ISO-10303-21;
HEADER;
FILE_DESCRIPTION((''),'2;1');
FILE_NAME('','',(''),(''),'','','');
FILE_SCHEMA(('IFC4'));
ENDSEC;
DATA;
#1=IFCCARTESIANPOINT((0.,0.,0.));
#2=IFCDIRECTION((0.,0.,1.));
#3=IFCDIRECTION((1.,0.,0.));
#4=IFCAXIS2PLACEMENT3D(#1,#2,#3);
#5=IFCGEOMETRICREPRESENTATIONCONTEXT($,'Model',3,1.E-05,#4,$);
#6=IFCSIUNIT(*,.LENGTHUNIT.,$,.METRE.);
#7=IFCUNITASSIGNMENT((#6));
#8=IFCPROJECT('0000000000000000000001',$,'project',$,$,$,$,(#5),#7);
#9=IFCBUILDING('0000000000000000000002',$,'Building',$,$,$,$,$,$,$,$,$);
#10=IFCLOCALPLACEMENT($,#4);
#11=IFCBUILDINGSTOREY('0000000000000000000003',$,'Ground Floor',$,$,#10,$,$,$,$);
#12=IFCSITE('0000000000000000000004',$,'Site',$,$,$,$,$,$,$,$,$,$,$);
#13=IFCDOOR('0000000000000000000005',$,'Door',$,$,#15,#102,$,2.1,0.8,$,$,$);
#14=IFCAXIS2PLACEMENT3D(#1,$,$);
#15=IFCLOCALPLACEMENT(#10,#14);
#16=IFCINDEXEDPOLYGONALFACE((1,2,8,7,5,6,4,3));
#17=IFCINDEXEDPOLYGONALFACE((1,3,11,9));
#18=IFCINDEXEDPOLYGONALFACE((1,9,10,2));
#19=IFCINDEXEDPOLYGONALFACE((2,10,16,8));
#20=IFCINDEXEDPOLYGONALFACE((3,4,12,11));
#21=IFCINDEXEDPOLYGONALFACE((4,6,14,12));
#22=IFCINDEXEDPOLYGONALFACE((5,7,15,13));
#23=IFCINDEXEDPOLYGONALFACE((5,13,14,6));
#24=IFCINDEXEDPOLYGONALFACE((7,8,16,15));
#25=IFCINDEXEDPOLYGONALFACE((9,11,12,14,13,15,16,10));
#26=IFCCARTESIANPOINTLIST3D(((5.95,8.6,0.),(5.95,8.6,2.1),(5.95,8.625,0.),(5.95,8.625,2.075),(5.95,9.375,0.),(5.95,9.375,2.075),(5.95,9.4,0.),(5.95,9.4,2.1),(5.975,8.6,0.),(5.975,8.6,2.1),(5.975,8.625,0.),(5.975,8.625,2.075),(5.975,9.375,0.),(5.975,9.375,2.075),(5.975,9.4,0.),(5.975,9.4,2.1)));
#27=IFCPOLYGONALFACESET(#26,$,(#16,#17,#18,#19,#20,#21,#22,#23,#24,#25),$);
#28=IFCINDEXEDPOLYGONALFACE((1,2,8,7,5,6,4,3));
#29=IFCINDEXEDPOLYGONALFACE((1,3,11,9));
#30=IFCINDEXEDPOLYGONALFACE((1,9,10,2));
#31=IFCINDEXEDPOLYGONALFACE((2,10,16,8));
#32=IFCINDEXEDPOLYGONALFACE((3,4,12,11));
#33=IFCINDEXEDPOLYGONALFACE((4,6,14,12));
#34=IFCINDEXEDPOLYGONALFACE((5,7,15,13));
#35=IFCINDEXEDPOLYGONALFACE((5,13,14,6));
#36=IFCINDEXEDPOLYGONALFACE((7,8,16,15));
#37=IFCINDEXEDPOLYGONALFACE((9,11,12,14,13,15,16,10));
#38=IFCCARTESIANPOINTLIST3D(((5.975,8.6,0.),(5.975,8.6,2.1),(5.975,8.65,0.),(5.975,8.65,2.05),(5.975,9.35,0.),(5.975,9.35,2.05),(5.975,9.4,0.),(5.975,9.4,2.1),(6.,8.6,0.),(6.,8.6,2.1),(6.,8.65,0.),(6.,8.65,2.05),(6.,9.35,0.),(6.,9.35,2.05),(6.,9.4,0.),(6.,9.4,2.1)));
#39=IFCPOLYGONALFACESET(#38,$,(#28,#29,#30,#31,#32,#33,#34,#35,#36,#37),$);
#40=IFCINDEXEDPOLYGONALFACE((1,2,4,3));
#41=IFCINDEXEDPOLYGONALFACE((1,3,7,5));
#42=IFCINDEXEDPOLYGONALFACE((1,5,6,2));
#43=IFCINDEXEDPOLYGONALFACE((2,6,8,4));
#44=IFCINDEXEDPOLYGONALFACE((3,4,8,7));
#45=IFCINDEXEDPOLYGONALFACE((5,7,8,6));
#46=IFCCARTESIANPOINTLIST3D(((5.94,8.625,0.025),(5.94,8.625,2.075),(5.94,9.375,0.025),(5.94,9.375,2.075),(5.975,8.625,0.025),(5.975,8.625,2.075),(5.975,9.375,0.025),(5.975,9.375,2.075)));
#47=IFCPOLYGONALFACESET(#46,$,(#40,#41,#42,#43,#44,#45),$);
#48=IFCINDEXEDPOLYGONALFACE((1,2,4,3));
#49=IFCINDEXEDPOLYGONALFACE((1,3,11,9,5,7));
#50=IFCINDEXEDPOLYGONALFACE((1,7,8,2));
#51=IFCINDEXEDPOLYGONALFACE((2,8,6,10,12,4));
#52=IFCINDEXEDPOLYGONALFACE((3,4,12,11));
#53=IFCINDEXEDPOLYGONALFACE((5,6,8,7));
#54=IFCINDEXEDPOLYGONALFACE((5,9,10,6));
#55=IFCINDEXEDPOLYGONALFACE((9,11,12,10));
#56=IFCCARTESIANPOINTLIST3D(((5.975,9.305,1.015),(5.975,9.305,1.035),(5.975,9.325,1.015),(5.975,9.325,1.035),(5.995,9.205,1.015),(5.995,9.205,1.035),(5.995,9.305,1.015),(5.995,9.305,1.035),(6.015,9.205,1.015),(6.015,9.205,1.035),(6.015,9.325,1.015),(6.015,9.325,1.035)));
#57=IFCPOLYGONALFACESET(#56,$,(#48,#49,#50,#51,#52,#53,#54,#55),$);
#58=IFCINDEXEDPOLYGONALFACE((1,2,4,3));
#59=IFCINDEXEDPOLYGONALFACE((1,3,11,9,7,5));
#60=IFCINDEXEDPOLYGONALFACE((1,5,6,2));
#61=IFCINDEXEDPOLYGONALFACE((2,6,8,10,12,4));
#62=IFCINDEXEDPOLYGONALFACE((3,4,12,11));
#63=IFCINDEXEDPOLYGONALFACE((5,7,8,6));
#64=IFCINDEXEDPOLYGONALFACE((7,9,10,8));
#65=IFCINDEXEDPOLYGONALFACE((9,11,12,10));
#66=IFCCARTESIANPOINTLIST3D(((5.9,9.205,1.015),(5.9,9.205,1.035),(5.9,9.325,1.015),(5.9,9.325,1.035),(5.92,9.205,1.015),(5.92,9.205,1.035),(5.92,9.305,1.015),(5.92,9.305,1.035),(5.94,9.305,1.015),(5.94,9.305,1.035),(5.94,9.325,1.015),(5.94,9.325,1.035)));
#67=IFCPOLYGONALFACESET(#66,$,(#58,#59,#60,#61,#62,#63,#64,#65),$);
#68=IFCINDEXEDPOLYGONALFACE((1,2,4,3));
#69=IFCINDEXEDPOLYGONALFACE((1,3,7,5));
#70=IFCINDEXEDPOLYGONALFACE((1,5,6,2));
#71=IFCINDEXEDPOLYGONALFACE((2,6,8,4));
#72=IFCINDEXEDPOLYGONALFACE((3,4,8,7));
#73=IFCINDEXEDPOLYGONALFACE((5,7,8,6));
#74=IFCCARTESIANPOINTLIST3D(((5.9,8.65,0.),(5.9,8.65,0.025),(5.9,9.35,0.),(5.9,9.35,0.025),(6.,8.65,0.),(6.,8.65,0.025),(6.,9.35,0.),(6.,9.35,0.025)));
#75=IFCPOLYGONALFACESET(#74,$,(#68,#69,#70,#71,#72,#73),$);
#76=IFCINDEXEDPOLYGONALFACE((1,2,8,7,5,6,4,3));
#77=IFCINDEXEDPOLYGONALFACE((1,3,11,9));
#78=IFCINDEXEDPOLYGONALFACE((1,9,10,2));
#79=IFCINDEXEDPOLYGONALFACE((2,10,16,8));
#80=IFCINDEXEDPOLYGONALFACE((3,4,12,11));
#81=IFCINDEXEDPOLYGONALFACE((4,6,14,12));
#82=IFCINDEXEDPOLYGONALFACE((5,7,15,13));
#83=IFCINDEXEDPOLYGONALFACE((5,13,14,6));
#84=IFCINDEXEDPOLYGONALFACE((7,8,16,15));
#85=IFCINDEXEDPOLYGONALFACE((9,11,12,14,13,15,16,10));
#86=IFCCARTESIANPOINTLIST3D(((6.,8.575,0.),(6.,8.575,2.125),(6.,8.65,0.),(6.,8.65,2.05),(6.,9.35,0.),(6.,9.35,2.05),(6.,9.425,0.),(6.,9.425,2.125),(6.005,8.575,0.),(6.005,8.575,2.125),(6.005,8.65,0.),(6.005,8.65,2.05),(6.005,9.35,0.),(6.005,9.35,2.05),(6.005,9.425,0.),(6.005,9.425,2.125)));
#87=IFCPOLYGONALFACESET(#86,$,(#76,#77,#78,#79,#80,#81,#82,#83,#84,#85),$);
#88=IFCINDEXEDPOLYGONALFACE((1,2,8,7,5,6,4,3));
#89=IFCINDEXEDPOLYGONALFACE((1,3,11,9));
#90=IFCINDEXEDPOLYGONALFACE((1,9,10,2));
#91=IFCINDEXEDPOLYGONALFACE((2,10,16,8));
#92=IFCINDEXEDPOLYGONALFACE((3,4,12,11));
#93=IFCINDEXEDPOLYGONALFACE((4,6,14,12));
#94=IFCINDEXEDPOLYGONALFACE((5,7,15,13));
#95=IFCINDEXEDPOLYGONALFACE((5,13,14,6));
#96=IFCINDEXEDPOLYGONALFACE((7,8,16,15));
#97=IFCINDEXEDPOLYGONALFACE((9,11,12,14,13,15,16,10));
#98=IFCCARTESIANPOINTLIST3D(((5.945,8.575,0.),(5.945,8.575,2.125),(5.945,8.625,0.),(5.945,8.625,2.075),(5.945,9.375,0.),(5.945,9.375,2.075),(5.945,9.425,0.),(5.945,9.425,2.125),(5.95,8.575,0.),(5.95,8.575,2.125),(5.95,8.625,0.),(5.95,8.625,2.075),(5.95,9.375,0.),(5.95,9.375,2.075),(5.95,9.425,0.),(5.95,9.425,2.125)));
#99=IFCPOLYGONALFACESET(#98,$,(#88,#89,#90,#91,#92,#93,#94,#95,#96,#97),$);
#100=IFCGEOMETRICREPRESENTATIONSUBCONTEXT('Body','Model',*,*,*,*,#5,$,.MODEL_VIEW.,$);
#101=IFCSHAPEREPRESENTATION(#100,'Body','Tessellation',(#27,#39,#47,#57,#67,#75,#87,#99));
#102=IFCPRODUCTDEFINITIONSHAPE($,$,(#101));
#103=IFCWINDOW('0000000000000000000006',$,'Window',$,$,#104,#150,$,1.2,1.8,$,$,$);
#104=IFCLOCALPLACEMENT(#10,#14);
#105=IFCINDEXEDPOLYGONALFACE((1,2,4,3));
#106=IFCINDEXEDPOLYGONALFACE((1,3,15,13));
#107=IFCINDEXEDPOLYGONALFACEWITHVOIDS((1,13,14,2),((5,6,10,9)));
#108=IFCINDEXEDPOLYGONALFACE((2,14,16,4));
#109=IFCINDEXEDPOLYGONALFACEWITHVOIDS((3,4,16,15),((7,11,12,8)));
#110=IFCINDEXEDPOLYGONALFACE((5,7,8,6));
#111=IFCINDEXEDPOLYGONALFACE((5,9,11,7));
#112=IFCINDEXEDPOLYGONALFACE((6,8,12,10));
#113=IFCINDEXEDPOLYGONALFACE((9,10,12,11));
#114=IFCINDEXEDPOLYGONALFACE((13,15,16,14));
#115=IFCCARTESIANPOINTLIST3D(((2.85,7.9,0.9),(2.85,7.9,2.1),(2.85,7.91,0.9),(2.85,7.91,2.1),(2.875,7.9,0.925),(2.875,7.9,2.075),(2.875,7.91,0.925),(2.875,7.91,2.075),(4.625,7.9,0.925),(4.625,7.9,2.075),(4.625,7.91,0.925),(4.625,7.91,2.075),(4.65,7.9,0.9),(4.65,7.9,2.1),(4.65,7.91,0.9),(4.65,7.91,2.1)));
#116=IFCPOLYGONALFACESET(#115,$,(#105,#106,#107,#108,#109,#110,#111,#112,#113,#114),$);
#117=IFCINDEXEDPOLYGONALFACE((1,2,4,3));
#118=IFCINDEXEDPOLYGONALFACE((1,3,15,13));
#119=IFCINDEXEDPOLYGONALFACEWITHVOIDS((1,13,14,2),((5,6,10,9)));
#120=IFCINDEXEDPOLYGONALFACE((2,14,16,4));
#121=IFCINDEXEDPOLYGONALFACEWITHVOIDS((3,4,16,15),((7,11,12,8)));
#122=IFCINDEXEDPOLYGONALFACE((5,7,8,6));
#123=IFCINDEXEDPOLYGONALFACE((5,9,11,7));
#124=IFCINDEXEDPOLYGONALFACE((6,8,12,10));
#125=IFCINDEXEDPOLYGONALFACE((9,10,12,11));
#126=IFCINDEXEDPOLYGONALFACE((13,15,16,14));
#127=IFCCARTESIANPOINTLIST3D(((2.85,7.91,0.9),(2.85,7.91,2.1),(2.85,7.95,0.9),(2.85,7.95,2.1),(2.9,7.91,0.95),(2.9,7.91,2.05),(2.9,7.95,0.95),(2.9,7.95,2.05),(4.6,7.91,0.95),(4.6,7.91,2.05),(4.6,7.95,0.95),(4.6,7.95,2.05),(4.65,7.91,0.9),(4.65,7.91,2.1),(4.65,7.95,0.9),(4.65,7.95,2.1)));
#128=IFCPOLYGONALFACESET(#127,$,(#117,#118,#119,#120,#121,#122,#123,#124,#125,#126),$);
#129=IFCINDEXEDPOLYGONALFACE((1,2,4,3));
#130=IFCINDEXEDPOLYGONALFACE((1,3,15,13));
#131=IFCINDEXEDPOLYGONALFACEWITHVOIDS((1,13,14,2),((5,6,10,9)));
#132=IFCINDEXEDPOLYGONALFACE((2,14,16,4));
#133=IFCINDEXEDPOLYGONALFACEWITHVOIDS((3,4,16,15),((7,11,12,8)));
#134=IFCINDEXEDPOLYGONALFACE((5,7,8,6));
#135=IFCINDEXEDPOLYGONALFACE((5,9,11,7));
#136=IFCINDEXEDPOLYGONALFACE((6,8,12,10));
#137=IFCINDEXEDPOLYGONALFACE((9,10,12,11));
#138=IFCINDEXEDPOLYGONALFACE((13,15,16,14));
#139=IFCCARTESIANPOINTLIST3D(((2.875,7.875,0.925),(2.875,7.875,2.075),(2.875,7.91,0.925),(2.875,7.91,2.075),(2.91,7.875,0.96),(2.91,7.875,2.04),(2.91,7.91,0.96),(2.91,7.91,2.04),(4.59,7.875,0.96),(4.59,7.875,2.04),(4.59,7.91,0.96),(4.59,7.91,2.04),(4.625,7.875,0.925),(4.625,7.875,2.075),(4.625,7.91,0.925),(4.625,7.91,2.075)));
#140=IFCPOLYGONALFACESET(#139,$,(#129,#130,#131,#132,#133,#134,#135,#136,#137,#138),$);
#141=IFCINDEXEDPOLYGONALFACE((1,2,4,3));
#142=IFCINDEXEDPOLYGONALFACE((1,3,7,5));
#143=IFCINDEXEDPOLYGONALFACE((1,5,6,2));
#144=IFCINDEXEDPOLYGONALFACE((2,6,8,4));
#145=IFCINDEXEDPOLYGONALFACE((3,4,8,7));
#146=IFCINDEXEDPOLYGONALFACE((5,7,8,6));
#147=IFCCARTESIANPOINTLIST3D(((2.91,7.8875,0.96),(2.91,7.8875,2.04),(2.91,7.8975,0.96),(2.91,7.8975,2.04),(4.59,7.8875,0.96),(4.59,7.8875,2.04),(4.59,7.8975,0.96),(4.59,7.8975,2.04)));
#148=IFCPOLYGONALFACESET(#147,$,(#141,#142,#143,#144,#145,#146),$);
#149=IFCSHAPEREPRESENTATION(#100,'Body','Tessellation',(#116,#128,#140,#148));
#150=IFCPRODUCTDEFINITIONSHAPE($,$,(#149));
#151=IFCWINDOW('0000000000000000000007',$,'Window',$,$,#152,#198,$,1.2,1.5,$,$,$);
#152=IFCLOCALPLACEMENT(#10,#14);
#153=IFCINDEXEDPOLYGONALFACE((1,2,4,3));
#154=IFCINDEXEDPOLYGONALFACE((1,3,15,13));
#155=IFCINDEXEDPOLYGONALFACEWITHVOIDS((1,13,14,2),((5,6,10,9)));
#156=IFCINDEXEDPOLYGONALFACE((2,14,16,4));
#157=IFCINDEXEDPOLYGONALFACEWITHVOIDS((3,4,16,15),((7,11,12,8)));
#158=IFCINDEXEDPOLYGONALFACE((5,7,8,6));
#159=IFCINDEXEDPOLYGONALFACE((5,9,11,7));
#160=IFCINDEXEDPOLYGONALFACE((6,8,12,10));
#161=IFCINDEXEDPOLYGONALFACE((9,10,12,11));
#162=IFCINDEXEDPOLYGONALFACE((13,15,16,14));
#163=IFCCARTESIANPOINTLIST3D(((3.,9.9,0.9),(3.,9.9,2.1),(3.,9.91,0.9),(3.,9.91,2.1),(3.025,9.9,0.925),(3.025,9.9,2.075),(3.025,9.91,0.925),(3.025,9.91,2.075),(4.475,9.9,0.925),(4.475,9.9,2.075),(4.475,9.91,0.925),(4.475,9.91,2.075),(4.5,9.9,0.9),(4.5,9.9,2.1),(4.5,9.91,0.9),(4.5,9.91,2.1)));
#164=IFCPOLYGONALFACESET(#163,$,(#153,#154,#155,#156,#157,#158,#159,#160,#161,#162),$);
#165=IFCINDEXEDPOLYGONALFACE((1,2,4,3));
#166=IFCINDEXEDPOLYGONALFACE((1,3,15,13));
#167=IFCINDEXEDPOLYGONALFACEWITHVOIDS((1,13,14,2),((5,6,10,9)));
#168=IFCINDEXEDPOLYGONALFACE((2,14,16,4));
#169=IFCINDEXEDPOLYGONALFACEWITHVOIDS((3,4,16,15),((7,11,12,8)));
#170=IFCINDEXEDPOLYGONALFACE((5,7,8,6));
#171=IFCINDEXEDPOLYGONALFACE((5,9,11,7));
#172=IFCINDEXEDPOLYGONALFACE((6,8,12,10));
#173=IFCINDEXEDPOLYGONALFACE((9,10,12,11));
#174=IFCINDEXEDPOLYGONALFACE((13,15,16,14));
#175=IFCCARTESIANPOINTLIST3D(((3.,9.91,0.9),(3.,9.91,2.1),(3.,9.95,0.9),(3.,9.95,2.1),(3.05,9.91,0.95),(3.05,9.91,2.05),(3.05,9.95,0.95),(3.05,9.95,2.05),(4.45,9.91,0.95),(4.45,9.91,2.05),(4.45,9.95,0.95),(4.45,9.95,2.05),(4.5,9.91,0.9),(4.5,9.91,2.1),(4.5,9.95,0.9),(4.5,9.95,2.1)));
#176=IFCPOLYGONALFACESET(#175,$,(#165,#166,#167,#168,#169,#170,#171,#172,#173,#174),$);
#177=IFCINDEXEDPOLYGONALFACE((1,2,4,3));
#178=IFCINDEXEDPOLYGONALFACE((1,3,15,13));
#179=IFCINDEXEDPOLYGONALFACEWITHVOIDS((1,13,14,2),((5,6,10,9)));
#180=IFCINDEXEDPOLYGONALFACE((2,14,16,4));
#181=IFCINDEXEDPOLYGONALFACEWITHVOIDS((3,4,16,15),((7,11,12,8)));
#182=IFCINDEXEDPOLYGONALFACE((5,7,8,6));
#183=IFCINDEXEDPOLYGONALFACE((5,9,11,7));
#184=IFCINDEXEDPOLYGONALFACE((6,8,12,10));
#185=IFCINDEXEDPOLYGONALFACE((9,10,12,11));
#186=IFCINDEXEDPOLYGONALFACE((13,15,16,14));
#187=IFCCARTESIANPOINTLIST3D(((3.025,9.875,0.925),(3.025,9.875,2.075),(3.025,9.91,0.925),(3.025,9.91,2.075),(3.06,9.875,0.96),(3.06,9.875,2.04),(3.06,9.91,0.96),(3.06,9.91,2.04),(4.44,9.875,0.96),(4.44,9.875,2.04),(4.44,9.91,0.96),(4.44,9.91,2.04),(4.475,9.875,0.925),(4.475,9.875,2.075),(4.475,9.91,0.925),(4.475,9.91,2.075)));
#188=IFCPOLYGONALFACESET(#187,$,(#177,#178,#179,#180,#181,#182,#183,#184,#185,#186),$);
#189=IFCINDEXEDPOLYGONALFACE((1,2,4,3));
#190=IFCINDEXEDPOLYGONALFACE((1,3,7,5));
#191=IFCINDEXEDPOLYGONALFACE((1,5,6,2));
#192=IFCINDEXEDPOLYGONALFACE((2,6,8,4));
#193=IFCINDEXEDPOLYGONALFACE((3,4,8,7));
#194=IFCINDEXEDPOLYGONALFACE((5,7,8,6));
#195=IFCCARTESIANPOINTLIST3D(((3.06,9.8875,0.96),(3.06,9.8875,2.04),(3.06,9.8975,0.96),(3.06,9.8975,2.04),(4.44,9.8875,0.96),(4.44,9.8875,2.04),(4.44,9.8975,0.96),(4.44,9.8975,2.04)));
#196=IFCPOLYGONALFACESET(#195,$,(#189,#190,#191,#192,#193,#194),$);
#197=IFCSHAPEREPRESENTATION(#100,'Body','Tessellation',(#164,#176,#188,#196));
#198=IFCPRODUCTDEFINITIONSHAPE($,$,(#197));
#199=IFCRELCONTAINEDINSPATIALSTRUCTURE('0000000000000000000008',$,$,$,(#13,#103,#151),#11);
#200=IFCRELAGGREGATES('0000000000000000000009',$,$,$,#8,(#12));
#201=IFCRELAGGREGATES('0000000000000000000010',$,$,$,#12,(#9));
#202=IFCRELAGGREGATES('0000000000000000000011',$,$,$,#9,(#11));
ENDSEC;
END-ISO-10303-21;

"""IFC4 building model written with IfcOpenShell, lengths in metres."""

from ifc_helpers import new_model, si_unit, frame, origin_with_axes, place, context, subcontext, project, spatial, line, indexed_curve, outline, extrude, element, save


model = new_model("IFC4")

# Units and contexts
model_context = context("Model", 3, precision=1e-05, world=origin_with_axes())
body_context = subcontext(model_context, "Body", "Model", "MODEL_VIEW")
ifc_project = project(units=[si_unit("LENGTHUNIT", "METRE")], contexts=[model_context])

# Site, building, storey
site = spatial("IfcSite", under=ifc_project, Name="Site")
building = spatial("IfcBuilding", under=site, Name="Building")
storey_placement = place(None, origin_with_axes())
storey = spatial("IfcBuildingStorey", under=building, at=storey_placement, Name="Ground Floor")

# Door
door_1_placement = place(storey_placement, frame((6.0, 8.6, 0.0), z_axis=(0.0, 0.0, 1.0), x_axis=(0.0, 1.0, 0.0)))
element("IfcDoor", 1, at=door_1_placement, inside=storey, Name="Door", OverallHeight=2.1, OverallWidth=0.8, context=body_context, shape_type="SweptSolid", body=[
    extrude(outline(indexed_curve([(0.0, 0.0), (0.0, 2.1), (0.8, 2.1), (0.8, 0.0), (0.775, 0.0), (0.775, 2.075), (0.025, 2.075), (0.025, 0.0)], segments=[line(1, 2, 3, 4, 5, 6, 7, 8, 1)])), frame((0.0, 0.025, 0.0), z_axis=(0.0, -1.0, 0.0), x_axis=(1.0, 0.0, 0.0)), (0.0, 0.0, -1.0), 0.025),
    extrude(outline(indexed_curve([(0.0, 0.0), (0.0, 2.1), (0.8, 2.1), (0.8, 0.0), (0.75, 0.0), (0.75, 2.05), (0.05, 2.05), (0.05, 0.0)], segments=[line(1, 2, 3, 4, 5, 6, 7, 8, 1)])), frame((0.0, 0.0, 0.0), z_axis=(0.0, -1.0, 0.0), x_axis=(1.0, 0.0, 0.0)), (0.0, 0.0, -1.0), 0.025),
    extrude(outline(indexed_curve([(0.0, 0.0), (0.75, 0.0), (0.75, 0.035), (0.0, 0.035)], segments=[line(1, 2, 3, 4, 1)])), frame((0.025, 0.025, 0.025), z_axis=(0.0, 0.0, 1.0), x_axis=(1.0, 0.0, 0.0)), (0.0, 0.0, 1.0), 2.05),
    extrude(outline(indexed_curve([(0.0, 0.0), (0.0, -0.04), (-0.12, -0.04), (-0.12, -0.02), (-0.02, -0.02), (-0.02, 0.0)], segments=[line(1, 2, 3, 4, 5, 6, 1)])), frame((0.725, 0.025, 1.015), z_axis=(0.0, 0.0, 1.0), x_axis=(1.0, 0.0, 0.0)), (0.0, 0.0, 1.0), 0.02),
    extrude(outline(indexed_curve([(0.0, 0.0), (0.0, 0.04), (-0.12, 0.04), (-0.12, 0.02), (-0.02, 0.02), (-0.02, 0.0)], segments=[line(1, 2, 3, 4, 5, 6, 1)])), frame((0.725, 0.06, 1.015), z_axis=(0.0, 0.0, 1.0), x_axis=(1.0, 0.0, 0.0)), (0.0, 0.0, 1.0), 0.02),
    extrude(outline(indexed_curve([(0.0, 0.0), (0.7, 0.0), (0.7, 0.1), (0.0, 0.1)], segments=[line(1, 2, 3, 4, 1)])), frame((0.05, 0.0, 0.0), z_axis=(0.0, 0.0, 1.0), x_axis=(1.0, 0.0, 0.0)), (0.0, 0.0, 1.0), 0.025),
    extrude(outline(indexed_curve([(0.0, 0.0), (0.0, 2.125), (0.85, 2.125), (0.85, 0.0), (0.775, 0.0), (0.775, 2.05), (0.075, 2.05), (0.075, 0.0)], segments=[line(1, 2, 3, 4, 5, 6, 7, 8, 1)])), frame((-0.025, -0.005, 0.0), z_axis=(0.0, -1.0, 0.0), x_axis=(1.0, 0.0, 0.0)), (0.0, 0.0, -1.0), 0.005),
    extrude(outline(indexed_curve([(0.0, 0.0), (0.0, 2.125), (0.85, 2.125), (0.85, 0.0), (0.8, 0.0), (0.8, 2.075), (0.05, 2.075), (0.05, 0.0)], segments=[line(1, 2, 3, 4, 5, 6, 7, 8, 1)])), frame((-0.025, 0.05, 0.0), z_axis=(0.0, -1.0, 0.0), x_axis=(1.0, 0.0, 0.0)), (0.0, 0.0, -1.0), 0.005),
])

# Windows
window_1_placement = place(storey_placement, frame((4.65, 8.0, 0.9), z_axis=(0.0, 0.0, 1.0), x_axis=(-1.0, 0.0, 0.0)))
element("IfcWindow", 2, at=window_1_placement, inside=storey, Name="Window", OverallHeight=1.2, OverallWidth=1.8, context=body_context, shape_type="SweptSolid", body=[
    extrude(outline(indexed_curve([(0.0, 0.0), (1.8, 0.0), (1.8, 1.2), (0.0, 1.2)], segments=[line(1, 2, 3, 4, 1)]), holes=[indexed_curve([(0.025, 0.025), (1.775, 0.025), (1.775, 1.175), (0.025, 1.175)], segments=[line(1, 2, 3, 4, 1)])]), frame((0.0, 0.09, 0.0), z_axis=(0.0, -1.0, 0.0), x_axis=(1.0, 0.0, 0.0)), (0.0, 0.0, -1.0), 0.01),
    extrude(outline(indexed_curve([(0.0, 0.0), (1.8, 0.0), (1.8, 1.2), (0.0, 1.2)], segments=[line(1, 2, 3, 4, 1)]), holes=[indexed_curve([(0.05, 0.05), (1.75, 0.05), (1.75, 1.15), (0.05, 1.15)], segments=[line(1, 2, 3, 4, 1)])]), frame((0.0, 0.05, 0.0), z_axis=(0.0, -1.0, 0.0), x_axis=(1.0, 0.0, 0.0)), (0.0, 0.0, -1.0), 0.04),
    extrude(outline(indexed_curve([(0.0, 0.0), (1.75, 0.0), (1.75, 1.15), (0.0, 1.15)], segments=[line(1, 2, 3, 4, 1)]), holes=[indexed_curve([(0.035, 0.035), (1.715, 0.035), (1.715, 1.115), (0.035, 1.115)], segments=[line(1, 2, 3, 4, 1)])]), frame((0.025, 0.09, 0.025), z_axis=(0.0, -1.0, 0.0), x_axis=(1.0, 0.0, 0.0)), (0.0, 0.0, -1.0), 0.035),
    extrude(outline(indexed_curve([(0.035, 0.035), (1.715, 0.035), (1.715, 1.115), (0.035, 1.115)], segments=[line(1, 2, 3, 4, 1)])), frame((0.025, 0.1025, 0.025), z_axis=(0.0, -1.0, 0.0), x_axis=(1.0, 0.0, 0.0)), (0.0, 0.0, -1.0), 0.01),
])
window_2_placement = place(storey_placement, frame((4.5, 10.0, 0.9), z_axis=(0.0, 0.0, 1.0), x_axis=(-1.0, 0.0, 0.0)))
element("IfcWindow", 3, at=window_2_placement, inside=storey, Name="Window", OverallHeight=1.2, OverallWidth=1.5, context=body_context, shape_type="SweptSolid", body=[
    extrude(outline(indexed_curve([(0.0, 0.0), (1.5, 0.0), (1.5, 1.2), (0.0, 1.2)], segments=[line(1, 2, 3, 4, 1)]), holes=[indexed_curve([(0.025, 0.025), (1.475, 0.025), (1.475, 1.175), (0.025, 1.175)], segments=[line(1, 2, 3, 4, 1)])]), frame((0.0, 0.09, 0.0), z_axis=(0.0, -1.0, 0.0), x_axis=(1.0, 0.0, 0.0)), (0.0, 0.0, -1.0), 0.01),
    extrude(outline(indexed_curve([(0.0, 0.0), (1.5, 0.0), (1.5, 1.2), (0.0, 1.2)], segments=[line(1, 2, 3, 4, 1)]), holes=[indexed_curve([(0.05, 0.05), (1.45, 0.05), (1.45, 1.15), (0.05, 1.15)], segments=[line(1, 2, 3, 4, 1)])]), frame((0.0, 0.05, 0.0), z_axis=(0.0, -1.0, 0.0), x_axis=(1.0, 0.0, 0.0)), (0.0, 0.0, -1.0), 0.04),
    extrude(outline(indexed_curve([(0.0, 0.0), (1.45, 0.0), (1.45, 1.15), (0.0, 1.15)], segments=[line(1, 2, 3, 4, 1)]), holes=[indexed_curve([(0.035, 0.035), (1.415, 0.035), (1.415, 1.115), (0.035, 1.115)], segments=[line(1, 2, 3, 4, 1)])]), frame((0.025, 0.09, 0.025), z_axis=(0.0, -1.0, 0.0), x_axis=(1.0, 0.0, 0.0)), (0.0, 0.0, -1.0), 0.035),
    extrude(outline(indexed_curve([(0.035, 0.035), (1.415, 0.035), (1.415, 1.115), (0.035, 1.115)], segments=[line(1, 2, 3, 4, 1)])), frame((0.025, 0.1025, 0.025), z_axis=(0.0, -1.0, 0.0), x_axis=(1.0, 0.0, 0.0)), (0.0, 0.0, -1.0), 0.01),
])

save(model, "model.ifc")
